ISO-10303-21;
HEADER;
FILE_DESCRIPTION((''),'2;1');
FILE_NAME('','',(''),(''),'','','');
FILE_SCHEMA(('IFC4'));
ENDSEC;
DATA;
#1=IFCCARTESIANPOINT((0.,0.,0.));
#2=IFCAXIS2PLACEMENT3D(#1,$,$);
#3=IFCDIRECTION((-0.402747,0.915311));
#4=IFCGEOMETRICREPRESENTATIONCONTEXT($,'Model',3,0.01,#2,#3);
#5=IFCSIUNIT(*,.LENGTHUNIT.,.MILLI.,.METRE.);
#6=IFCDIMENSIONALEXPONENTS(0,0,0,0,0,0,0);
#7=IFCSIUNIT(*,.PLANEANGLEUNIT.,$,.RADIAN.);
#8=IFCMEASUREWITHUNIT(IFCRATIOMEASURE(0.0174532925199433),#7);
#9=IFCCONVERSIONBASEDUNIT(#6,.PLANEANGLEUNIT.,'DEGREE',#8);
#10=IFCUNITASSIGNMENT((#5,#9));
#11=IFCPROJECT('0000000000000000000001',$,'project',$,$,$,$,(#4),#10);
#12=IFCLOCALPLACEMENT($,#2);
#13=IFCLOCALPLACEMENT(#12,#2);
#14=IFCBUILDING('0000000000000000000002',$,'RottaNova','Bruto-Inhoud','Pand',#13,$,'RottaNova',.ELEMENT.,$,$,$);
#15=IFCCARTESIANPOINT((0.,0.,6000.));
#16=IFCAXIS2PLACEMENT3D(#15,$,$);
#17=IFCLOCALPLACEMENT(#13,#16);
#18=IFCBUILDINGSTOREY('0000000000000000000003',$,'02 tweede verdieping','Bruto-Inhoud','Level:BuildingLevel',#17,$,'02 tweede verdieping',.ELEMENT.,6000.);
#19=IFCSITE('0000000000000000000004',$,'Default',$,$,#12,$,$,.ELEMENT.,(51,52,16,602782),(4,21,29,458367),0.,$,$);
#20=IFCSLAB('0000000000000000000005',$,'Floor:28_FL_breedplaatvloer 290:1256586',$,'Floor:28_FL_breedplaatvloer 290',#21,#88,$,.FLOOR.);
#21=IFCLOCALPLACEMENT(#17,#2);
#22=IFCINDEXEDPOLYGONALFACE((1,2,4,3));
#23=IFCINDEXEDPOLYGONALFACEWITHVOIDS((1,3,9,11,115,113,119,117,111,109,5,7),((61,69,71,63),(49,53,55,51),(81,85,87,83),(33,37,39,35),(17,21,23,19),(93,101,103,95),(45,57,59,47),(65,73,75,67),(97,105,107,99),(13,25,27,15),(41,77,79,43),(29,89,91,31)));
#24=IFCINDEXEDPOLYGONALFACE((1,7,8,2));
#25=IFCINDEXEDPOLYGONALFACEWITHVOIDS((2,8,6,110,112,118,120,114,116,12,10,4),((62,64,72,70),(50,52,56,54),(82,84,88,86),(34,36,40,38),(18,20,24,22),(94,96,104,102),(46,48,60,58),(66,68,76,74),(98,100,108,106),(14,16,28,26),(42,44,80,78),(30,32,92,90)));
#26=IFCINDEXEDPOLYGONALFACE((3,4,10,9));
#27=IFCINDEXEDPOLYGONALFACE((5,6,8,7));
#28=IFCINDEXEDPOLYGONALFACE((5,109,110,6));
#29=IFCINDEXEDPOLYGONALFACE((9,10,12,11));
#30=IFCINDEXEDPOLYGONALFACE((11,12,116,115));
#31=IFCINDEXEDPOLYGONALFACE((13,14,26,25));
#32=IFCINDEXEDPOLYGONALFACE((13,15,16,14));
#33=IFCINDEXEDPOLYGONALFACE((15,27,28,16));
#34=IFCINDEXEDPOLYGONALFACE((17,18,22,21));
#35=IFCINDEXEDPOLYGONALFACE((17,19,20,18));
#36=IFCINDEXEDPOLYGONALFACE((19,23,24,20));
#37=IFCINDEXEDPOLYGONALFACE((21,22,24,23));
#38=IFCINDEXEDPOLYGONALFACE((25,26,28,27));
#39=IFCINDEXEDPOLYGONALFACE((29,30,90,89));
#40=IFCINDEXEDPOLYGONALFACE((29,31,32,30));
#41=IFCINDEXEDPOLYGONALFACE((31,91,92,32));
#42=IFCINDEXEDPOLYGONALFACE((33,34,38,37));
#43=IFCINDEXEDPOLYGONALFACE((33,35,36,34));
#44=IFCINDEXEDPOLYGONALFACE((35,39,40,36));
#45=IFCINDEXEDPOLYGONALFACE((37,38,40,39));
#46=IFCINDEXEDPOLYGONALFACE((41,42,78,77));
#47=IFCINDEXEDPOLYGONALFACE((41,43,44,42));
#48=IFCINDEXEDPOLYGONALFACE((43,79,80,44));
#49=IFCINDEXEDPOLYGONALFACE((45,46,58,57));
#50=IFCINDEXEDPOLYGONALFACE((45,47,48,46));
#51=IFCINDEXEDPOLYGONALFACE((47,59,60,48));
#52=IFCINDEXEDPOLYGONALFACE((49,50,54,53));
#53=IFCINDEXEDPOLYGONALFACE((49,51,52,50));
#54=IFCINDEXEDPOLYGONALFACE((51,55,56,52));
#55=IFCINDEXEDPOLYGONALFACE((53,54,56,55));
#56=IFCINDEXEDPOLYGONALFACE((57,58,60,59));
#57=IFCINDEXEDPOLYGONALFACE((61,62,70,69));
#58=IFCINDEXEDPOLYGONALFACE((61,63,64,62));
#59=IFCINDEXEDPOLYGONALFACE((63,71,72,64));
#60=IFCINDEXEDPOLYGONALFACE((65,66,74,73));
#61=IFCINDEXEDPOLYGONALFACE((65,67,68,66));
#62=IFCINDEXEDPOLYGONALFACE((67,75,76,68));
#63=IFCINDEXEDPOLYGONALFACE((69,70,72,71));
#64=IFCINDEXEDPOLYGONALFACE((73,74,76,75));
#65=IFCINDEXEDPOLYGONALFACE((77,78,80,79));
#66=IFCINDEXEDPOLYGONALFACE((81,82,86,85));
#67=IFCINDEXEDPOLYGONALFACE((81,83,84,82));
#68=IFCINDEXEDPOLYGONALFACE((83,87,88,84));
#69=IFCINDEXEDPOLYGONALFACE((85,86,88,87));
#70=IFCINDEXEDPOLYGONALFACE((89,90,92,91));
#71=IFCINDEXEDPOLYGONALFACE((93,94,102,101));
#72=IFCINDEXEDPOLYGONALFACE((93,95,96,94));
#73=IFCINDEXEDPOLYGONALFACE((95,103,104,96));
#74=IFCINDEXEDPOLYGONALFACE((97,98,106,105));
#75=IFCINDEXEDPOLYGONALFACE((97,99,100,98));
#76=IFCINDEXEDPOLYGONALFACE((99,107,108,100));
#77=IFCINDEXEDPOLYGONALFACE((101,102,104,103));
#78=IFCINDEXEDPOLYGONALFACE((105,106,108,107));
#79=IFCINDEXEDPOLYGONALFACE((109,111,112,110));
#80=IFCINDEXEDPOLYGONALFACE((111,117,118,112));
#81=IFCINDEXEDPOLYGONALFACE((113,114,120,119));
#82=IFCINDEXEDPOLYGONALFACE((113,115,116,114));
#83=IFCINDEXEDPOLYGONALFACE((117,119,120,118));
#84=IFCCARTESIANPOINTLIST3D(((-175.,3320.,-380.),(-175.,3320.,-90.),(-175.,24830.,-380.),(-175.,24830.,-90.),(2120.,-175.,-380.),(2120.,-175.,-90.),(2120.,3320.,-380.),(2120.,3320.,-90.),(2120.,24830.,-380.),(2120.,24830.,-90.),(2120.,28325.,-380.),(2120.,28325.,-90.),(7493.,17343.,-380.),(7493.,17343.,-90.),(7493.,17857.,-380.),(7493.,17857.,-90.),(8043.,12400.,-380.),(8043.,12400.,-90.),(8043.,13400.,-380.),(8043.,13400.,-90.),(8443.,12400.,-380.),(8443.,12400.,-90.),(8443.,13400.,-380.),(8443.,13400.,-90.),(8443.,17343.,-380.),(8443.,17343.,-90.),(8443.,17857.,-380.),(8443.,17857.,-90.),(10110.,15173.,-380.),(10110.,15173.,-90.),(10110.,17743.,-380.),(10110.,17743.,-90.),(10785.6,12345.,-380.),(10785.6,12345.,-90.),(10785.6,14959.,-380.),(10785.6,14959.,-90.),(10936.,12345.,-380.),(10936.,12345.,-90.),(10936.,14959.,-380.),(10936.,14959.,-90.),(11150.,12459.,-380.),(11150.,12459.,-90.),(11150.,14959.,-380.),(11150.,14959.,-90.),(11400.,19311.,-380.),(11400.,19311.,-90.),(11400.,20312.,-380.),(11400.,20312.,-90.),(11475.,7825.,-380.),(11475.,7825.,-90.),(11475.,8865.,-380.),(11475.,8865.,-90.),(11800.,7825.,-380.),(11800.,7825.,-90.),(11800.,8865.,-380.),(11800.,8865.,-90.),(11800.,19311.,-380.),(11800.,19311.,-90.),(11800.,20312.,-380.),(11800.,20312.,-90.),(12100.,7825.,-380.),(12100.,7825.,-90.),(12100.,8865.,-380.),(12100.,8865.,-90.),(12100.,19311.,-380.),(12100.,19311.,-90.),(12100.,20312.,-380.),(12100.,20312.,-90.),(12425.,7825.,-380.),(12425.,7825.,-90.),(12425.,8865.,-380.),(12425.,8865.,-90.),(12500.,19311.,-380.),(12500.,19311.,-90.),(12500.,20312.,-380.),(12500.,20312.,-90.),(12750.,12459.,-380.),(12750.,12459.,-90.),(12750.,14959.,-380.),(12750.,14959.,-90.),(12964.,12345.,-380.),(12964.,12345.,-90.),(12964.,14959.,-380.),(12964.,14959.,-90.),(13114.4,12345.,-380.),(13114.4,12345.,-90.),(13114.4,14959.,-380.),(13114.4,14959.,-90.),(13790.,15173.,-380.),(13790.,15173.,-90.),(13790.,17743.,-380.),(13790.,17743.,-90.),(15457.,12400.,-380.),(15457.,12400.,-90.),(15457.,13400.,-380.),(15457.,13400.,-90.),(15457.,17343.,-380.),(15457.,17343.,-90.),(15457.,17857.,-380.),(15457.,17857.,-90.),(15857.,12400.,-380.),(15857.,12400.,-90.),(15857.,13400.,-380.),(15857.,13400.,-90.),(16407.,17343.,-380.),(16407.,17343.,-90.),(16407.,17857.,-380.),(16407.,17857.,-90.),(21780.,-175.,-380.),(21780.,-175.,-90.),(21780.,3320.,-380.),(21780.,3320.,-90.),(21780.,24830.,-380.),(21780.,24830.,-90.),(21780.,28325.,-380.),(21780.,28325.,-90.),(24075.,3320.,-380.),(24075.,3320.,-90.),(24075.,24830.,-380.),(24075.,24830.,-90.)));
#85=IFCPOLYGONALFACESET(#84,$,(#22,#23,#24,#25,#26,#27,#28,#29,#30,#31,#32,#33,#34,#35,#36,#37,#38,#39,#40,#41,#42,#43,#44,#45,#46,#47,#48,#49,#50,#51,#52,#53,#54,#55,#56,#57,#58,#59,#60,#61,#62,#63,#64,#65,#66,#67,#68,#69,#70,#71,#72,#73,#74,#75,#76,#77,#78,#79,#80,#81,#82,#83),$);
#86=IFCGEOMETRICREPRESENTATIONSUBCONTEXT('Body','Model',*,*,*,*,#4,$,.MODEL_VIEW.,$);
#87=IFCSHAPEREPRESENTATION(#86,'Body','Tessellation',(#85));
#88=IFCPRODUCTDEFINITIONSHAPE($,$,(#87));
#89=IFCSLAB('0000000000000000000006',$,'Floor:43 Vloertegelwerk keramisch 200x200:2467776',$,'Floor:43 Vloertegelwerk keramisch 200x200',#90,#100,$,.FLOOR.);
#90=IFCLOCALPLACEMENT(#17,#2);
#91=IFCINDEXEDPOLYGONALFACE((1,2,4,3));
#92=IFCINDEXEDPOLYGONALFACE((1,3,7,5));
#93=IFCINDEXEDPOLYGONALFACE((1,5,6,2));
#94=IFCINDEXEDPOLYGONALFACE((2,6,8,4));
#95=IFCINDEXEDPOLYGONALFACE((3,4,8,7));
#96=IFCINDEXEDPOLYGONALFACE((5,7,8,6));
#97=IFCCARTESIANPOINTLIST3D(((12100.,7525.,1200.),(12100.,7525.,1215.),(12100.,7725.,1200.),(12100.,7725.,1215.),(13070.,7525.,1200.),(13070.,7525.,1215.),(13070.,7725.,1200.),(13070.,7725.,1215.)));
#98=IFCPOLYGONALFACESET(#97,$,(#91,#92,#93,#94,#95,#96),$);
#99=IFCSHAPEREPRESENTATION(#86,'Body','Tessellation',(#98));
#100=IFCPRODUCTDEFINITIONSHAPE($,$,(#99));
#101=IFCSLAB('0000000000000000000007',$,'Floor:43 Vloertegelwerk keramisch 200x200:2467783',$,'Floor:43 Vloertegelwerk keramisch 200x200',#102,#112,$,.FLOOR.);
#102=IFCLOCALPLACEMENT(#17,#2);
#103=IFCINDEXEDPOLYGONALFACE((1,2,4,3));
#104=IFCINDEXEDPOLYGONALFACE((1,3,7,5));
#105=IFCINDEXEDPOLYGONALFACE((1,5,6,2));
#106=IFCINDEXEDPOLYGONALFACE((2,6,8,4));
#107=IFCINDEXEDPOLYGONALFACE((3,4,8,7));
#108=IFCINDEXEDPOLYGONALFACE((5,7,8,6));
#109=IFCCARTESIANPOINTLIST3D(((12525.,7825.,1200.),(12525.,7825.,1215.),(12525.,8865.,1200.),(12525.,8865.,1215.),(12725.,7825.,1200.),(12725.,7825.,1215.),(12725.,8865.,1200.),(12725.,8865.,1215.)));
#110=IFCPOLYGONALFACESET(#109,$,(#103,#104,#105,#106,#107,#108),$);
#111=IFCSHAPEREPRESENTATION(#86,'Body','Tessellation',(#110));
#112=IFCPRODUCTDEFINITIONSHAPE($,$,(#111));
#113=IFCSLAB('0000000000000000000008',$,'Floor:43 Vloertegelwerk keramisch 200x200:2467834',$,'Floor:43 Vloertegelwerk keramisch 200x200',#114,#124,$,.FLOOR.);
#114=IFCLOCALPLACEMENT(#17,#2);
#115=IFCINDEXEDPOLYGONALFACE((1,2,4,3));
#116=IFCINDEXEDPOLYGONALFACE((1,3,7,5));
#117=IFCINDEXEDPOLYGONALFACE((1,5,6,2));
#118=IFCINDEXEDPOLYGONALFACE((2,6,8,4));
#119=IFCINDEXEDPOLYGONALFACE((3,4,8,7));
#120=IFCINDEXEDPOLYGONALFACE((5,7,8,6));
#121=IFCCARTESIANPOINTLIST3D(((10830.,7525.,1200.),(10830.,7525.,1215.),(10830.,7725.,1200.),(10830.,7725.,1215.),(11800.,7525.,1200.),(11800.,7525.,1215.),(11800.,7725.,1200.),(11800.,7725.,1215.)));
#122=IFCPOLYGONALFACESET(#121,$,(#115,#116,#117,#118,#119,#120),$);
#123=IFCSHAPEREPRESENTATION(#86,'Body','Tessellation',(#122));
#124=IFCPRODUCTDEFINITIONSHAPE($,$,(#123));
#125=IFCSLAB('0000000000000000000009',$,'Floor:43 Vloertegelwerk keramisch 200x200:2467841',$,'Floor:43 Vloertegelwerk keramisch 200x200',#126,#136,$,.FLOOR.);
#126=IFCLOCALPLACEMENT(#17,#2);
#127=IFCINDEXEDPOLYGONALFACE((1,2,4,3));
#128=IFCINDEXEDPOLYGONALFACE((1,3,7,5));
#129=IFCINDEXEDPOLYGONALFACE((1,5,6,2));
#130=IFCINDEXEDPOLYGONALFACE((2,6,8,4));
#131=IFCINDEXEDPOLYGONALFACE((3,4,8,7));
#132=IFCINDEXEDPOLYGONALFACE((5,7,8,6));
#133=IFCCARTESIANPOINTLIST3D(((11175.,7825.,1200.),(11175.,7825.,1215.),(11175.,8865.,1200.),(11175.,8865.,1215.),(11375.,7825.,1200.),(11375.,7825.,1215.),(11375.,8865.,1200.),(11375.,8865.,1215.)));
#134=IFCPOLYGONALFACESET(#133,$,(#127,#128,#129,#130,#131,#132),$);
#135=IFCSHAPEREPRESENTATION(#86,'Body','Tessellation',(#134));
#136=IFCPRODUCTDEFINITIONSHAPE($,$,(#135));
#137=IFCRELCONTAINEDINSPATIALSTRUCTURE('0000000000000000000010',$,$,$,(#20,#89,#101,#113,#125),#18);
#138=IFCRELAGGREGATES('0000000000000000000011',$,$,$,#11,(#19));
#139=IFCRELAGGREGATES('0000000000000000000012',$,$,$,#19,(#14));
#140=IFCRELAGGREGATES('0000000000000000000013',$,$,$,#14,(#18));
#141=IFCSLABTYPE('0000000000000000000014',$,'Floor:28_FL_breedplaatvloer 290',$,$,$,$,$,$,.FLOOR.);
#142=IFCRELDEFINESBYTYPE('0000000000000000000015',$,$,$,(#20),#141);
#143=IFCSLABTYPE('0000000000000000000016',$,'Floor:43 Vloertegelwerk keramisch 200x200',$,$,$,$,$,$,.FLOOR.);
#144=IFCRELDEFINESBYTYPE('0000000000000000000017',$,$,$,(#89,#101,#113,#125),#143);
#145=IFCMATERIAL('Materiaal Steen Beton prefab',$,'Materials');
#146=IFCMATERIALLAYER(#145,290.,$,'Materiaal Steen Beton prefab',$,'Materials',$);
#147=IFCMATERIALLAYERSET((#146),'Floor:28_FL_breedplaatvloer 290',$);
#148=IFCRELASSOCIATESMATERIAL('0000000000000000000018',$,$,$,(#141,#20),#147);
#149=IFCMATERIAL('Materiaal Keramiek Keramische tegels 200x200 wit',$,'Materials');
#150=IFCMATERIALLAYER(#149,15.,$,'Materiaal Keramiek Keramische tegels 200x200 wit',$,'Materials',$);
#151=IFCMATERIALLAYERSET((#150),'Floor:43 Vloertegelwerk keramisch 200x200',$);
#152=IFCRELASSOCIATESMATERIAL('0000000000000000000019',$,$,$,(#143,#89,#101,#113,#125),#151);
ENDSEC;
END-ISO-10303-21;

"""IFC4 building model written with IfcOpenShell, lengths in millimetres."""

from ifc_helpers import new_model, entity, si_unit, converted_unit, direction, frame, frame_2d, origin, origin_2d_with_axis, place, context, subcontext, project, spatial, polyline, rectangle, outline, extrude, material, layer, layer_set, layer_usage, type_object, element, save


model = new_model("IFC4")

# Units and contexts
model_context = context("Model", 3, precision=0.01, world=origin(), true_north=direction((-0.402747, 0.915311)))
body_context = subcontext(model_context, "Body", "Model", "MODEL_VIEW")
ifc_project = project(units=[si_unit("LENGTHUNIT", "METRE", prefix="MILLI"), converted_unit("PLANEANGLEUNIT", "DEGREE", entity("IfcRatioMeasure", 0.0174532925199433), si_unit("PLANEANGLEUNIT", "RADIAN"), dimensions=[0, 0, 0, 0, 0, 0, 0])], contexts=[model_context])

# Site, building, storey
site_placement = place(None, origin())
site = spatial("IfcSite", under=ifc_project, at=site_placement, Name="Default", CompositionType="ELEMENT", RefLatitude=(51, 52, 16, 602782), RefLongitude=(4, 21, 29, 458367), RefElevation=0.0)
building_placement = place(site_placement, origin())
building = spatial("IfcBuilding", under=site, at=building_placement, Name="RottaNova", Description="Bruto-Inhoud", ObjectType="Pand", LongName="RottaNova", CompositionType="ELEMENT")
storey_placement = place(building_placement, frame((0.0, 0.0, 6000.0)))
storey = spatial("IfcBuildingStorey", under=building, at=storey_placement, Name="02 tweede verdieping", Description="Bruto-Inhoud", ObjectType="Level:BuildingLevel", LongName="02 tweede verdieping", CompositionType="ELEMENT", Elevation=6000.0)

# Slab, openings
ifc_material_1 = material(Name="Materiaal Steen Beton prefab", Category="Materials")
ifc_layer_1 = layer(ifc_material_1, 290.0, Name="Materiaal Steen Beton prefab", Category="Materials")
ifc_layer_set_1 = layer_set([ifc_layer_1], Name="Floor:28_FL_breedplaatvloer 290")
ifc_layer_usage_1 = layer_usage(ifc_layer_set_1, "AXIS3", "POSITIVE", 0.0)
slab_type_1 = type_object("IfcSlabType", Name="Floor:28_FL_breedplaatvloer 290", PredefinedType="FLOOR", material=ifc_layer_set_1)
slab_1_placement = place(storey_placement, frame((-175.0, -175.0, -380.0)))
slab_1 = element("IfcSlab", 1, at=slab_1_placement, inside=storey, type_object=slab_type_1, material=ifc_layer_usage_1, Name="Floor:28_FL_breedplaatvloer 290:1256586", ObjectType="Floor:28_FL_breedplaatvloer 290", PredefinedType="FLOOR", context=body_context, shape_type="SweptSolid", body=[
    extrude(outline(polyline([(-9830.0, 14250.0), (-9830.0, 10755.0), (-12125.0, 10755.0), (-12125.0, -10755.0), (-9830.0, -10755.0), (-9830.0, -14250.0), (9830.0, -14250.0), (9830.0, -10755.0), (12125.0, -10755.0), (12125.0, 10755.0), (9830.0, 10755.0), (9830.0, 14250.0), (-9830.0, 14250.0)])), frame((12125.0, 14250.0, 290.0), z_axis=(0.0, 0.0, -1.0), x_axis=(-1.0, 0.0, 0.0)), (0.0, 0.0, 1.0), 290.0),
])
opening_1_placement = place(storey_placement, frame((-175.0, -175.0, -380.0)))
element("IfcOpeningElement", 2, at=opening_1_placement, cuts=slab_1, ObjectType="Opening", context=body_context, shape_type="SweptSolid", body=[
    extrude(rectangle(XDim=1040.0, YDim=325.0, at=frame_2d((-312.5, -5730.0), x_axis=(0.0, -1.0))), frame((12125.0, 14250.0, 290.0), z_axis=(0.0, 0.0, -1.0), x_axis=(-1.0, 0.0, 0.0)), (0.0, 0.0, 1.0), 290.0),
])
opening_2_placement = place(storey_placement, frame((-175.0, -175.0, -380.0)))
element("IfcOpeningElement", 3, at=opening_2_placement, cuts=slab_1, ObjectType="Opening", context=body_context, shape_type="SweptSolid", body=[
    extrude(rectangle(XDim=514.0, YDim=950.0, at=frame_2d((-3982.0, 3525.0), x_axis=(0.0, -1.0))), frame((12125.0, 14250.0, 290.0), z_axis=(0.0, 0.0, -1.0), x_axis=(-1.0, 0.0, 0.0)), (0.0, 0.0, 1.0), 290.0),
])
opening_3_placement = place(storey_placement, frame((-175.0, -175.0, -380.0)))
element("IfcOpeningElement", 4, at=opening_3_placement, cuts=slab_1, ObjectType="Opening", context=body_context, shape_type="SweptSolid", body=[
    extrude(rectangle(XDim=400.0, YDim=1001.0, at=frame_2d((-350.0, 5736.5), x_axis=(1.0, 0.0))), frame((12125.0, 14250.0, 290.0), z_axis=(0.0, 0.0, -1.0), x_axis=(-1.0, 0.0, 0.0)), (0.0, 0.0, 1.0), 290.0),
])
opening_4_placement = place(storey_placement, frame((-175.0, -175.0, -380.0)))
element("IfcOpeningElement", 5, at=opening_4_placement, cuts=slab_1, ObjectType="Opening", context=body_context, shape_type="SweptSolid", body=[
    extrude(rectangle(XDim=400.0, YDim=1000.0, at=frame_2d((-3707.0, -1175.0), x_axis=(1.0, 0.0))), frame((12125.0, 14250.0, 290.0), z_axis=(0.0, 0.0, -1.0), x_axis=(-1.0, 0.0, 0.0)), (0.0, 0.0, 1.0), 290.0),
])
opening_5_placement = place(storey_placement, frame((-175.0, -175.0, -380.0)))
element("IfcOpeningElement", 6, at=opening_5_placement, cuts=slab_1, ObjectType="Opening", context=body_context, shape_type="SweptSolid", body=[
    extrude(rectangle(XDim=400.0, YDim=1000.0, at=frame_2d((3707.0, -1175.0), x_axis=(-1.0, 0.0))), frame((12125.0, 14250.0, 290.0), z_axis=(0.0, 0.0, -1.0), x_axis=(-1.0, 0.0, 0.0)), (0.0, 0.0, 1.0), 290.0),
])
opening_6_placement = place(storey_placement, frame((-175.0, -175.0, -380.0)))
element("IfcOpeningElement", 7, at=opening_6_placement, cuts=slab_1, ObjectType="Opening", context=body_context, shape_type="SweptSolid", body=[
    extrude(rectangle(XDim=1040.0, YDim=325.0, at=frame_2d((312.5, -5730.0), x_axis=(0.0, -1.0))), frame((12125.0, 14250.0, 290.0), z_axis=(0.0, 0.0, -1.0), x_axis=(-1.0, 0.0, 0.0)), (0.0, 0.0, 1.0), 290.0),
])
opening_7_placement = place(storey_placement, frame((-175.0, -175.0, -380.0)))
element("IfcOpeningElement", 8, at=opening_7_placement, cuts=slab_1, ObjectType="Opening", context=body_context, shape_type="SweptSolid", body=[
    extrude(rectangle(XDim=400.0, YDim=1001.0, at=frame_2d((350.0, 5736.5), x_axis=(-1.0, 0.0))), frame((12125.0, 14250.0, 290.0), z_axis=(0.0, 0.0, -1.0), x_axis=(-1.0, 0.0, 0.0)), (0.0, 0.0, 1.0), 290.0),
])
opening_8_placement = place(storey_placement, frame((-175.0, -175.0, -380.0)))
element("IfcOpeningElement", 9, at=opening_8_placement, cuts=slab_1, ObjectType="Opening", context=body_context, shape_type="SweptSolid", body=[
    extrude(rectangle(XDim=514.0, YDim=950.0, at=frame_2d((3982.0, 3525.0), x_axis=(0.0, -1.0))), frame((12125.0, 14250.0, 290.0), z_axis=(0.0, 0.0, -1.0), x_axis=(-1.0, 0.0, 0.0)), (0.0, 0.0, 1.0), 290.0),
])
opening_9_placement = place(storey_placement, frame((-175.0, -175.0, -380.0)))
element("IfcOpeningElement", 10, at=opening_9_placement, cuts=slab_1, ObjectType="Opening", context=body_context, shape_type="SweptSolid", body=[
    extrude(rectangle(XDim=150.4, YDim=2614.0, at=frame_2d((1089.2, -423.0), x_axis=(1.0, 0.0))), frame((12125.0, 14250.0, 290.0), z_axis=(0.0, 0.0, -1.0), x_axis=(-1.0, 0.0, 0.0)), (0.0, 0.0, 1.0), 290.0),
])
opening_10_placement = place(storey_placement, frame((-175.0, -175.0, -380.0)))
element("IfcOpeningElement", 11, at=opening_10_placement, cuts=slab_1, ObjectType="Opening", context=body_context, shape_type="SweptSolid", body=[
    extrude(rectangle(XDim=150.4, YDim=2614.0, at=frame_2d((-1089.2, -423.0), x_axis=(-1.0, 0.0))), frame((12125.0, 14250.0, 290.0), z_axis=(0.0, 0.0, -1.0), x_axis=(-1.0, 0.0, 0.0)), (0.0, 0.0, 1.0), 290.0),
])
opening_11_placement = place(slab_1_placement, frame((12125.0, 13884.0, 290.0)))
element("IfcOpeningElement", 12, at=opening_11_placement, cuts=slab_1, ObjectType="Opening", context=body_context, shape_type="SweptSolid", body=[
    extrude(rectangle(XDim=2500.0, YDim=1600.0, at=origin_2d_with_axis()), frame((0.0, 0.0, 0.0), z_axis=(0.0, 0.0, -1.0), x_axis=(0.0, -1.0, 0.0)), (0.0, 0.0, 1.0), 290.0),
])
opening_12_placement = place(slab_1_placement, frame((12125.0, 16633.0, 290.0)))
element("IfcOpeningElement", 13, at=opening_12_placement, cuts=slab_1, ObjectType="Opening", context=body_context, shape_type="SweptSolid", body=[
    extrude(rectangle(XDim=2570.0, YDim=3680.0, at=origin_2d_with_axis()), frame((0.0, 0.0, 0.0), z_axis=(0.0, 0.0, -1.0), x_axis=(0.0, 1.0, 0.0)), (0.0, 0.0, 1.0), 290.0),
])

# Slabs
ifc_material_2 = material(Name="Materiaal Keramiek Keramische tegels 200x200 wit", Category="Materials")
ifc_layer_2 = layer(ifc_material_2, 15.0, Name="Materiaal Keramiek Keramische tegels 200x200 wit", Category="Materials")
ifc_layer_set_2 = layer_set([ifc_layer_2], Name="Floor:43 Vloertegelwerk keramisch 200x200")
ifc_layer_usage_2 = layer_usage(ifc_layer_set_2, "AXIS3", "POSITIVE", 0.0)
slab_type_2 = type_object("IfcSlabType", Name="Floor:43 Vloertegelwerk keramisch 200x200", PredefinedType="FLOOR", material=ifc_layer_set_2)
slab_2_placement = place(storey_placement, origin())
element("IfcSlab", 14, at=slab_2_placement, inside=storey, type_object=slab_type_2, material=ifc_layer_usage_2, Name="Floor:43 Vloertegelwerk keramisch 200x200:2467776", ObjectType="Floor:43 Vloertegelwerk keramisch 200x200", PredefinedType="FLOOR", context=body_context, shape_type="SweptSolid", body=[
    extrude(rectangle(XDim=200.0, YDim=970.0, at=origin_2d_with_axis()), frame((12585.0, 7625.0, 1215.0), z_axis=(0.0, 0.0, -1.0), x_axis=(0.0, 1.0, 0.0)), (0.0, 0.0, 1.0), 15.0),
])
slab_3_placement = place(storey_placement, origin())
element("IfcSlab", 15, at=slab_3_placement, inside=storey, type_object=slab_type_2, material=ifc_layer_usage_2, Name="Floor:43 Vloertegelwerk keramisch 200x200:2467783", ObjectType="Floor:43 Vloertegelwerk keramisch 200x200", PredefinedType="FLOOR", context=body_context, shape_type="SweptSolid", body=[
    extrude(rectangle(XDim=1040.0, YDim=200.0, at=origin_2d_with_axis()), frame((12625.0, 8345.0, 1215.0), z_axis=(0.0, 0.0, -1.0), x_axis=(0.0, 1.0, 0.0)), (0.0, 0.0, 1.0), 15.0),
])
slab_4_placement = place(storey_placement, origin())
element("IfcSlab", 16, at=slab_4_placement, inside=storey, type_object=slab_type_2, material=ifc_layer_usage_2, Name="Floor:43 Vloertegelwerk keramisch 200x200:2467834", ObjectType="Floor:43 Vloertegelwerk keramisch 200x200", PredefinedType="FLOOR", context=body_context, shape_type="SweptSolid", body=[
    extrude(rectangle(XDim=200.0, YDim=970.0, at=origin_2d_with_axis()), frame((11315.0, 7625.0, 1215.0), z_axis=(0.0, 0.0, -1.0), x_axis=(0.0, 1.0, 0.0)), (0.0, 0.0, 1.0), 15.0),
])
slab_5_placement = place(storey_placement, origin())
element("IfcSlab", 17, at=slab_5_placement, inside=storey, type_object=slab_type_2, material=ifc_layer_usage_2, Name="Floor:43 Vloertegelwerk keramisch 200x200:2467841", ObjectType="Floor:43 Vloertegelwerk keramisch 200x200", PredefinedType="FLOOR", context=body_context, shape_type="SweptSolid", body=[
    extrude(rectangle(XDim=1040.0, YDim=200.0, at=origin_2d_with_axis()), frame((11275.0, 8345.0, 1215.0), z_axis=(0.0, 0.0, -1.0), x_axis=(0.0, 1.0, 0.0)), (0.0, 0.0, 1.0), 15.0),
])

save(model, "model.ifc")
